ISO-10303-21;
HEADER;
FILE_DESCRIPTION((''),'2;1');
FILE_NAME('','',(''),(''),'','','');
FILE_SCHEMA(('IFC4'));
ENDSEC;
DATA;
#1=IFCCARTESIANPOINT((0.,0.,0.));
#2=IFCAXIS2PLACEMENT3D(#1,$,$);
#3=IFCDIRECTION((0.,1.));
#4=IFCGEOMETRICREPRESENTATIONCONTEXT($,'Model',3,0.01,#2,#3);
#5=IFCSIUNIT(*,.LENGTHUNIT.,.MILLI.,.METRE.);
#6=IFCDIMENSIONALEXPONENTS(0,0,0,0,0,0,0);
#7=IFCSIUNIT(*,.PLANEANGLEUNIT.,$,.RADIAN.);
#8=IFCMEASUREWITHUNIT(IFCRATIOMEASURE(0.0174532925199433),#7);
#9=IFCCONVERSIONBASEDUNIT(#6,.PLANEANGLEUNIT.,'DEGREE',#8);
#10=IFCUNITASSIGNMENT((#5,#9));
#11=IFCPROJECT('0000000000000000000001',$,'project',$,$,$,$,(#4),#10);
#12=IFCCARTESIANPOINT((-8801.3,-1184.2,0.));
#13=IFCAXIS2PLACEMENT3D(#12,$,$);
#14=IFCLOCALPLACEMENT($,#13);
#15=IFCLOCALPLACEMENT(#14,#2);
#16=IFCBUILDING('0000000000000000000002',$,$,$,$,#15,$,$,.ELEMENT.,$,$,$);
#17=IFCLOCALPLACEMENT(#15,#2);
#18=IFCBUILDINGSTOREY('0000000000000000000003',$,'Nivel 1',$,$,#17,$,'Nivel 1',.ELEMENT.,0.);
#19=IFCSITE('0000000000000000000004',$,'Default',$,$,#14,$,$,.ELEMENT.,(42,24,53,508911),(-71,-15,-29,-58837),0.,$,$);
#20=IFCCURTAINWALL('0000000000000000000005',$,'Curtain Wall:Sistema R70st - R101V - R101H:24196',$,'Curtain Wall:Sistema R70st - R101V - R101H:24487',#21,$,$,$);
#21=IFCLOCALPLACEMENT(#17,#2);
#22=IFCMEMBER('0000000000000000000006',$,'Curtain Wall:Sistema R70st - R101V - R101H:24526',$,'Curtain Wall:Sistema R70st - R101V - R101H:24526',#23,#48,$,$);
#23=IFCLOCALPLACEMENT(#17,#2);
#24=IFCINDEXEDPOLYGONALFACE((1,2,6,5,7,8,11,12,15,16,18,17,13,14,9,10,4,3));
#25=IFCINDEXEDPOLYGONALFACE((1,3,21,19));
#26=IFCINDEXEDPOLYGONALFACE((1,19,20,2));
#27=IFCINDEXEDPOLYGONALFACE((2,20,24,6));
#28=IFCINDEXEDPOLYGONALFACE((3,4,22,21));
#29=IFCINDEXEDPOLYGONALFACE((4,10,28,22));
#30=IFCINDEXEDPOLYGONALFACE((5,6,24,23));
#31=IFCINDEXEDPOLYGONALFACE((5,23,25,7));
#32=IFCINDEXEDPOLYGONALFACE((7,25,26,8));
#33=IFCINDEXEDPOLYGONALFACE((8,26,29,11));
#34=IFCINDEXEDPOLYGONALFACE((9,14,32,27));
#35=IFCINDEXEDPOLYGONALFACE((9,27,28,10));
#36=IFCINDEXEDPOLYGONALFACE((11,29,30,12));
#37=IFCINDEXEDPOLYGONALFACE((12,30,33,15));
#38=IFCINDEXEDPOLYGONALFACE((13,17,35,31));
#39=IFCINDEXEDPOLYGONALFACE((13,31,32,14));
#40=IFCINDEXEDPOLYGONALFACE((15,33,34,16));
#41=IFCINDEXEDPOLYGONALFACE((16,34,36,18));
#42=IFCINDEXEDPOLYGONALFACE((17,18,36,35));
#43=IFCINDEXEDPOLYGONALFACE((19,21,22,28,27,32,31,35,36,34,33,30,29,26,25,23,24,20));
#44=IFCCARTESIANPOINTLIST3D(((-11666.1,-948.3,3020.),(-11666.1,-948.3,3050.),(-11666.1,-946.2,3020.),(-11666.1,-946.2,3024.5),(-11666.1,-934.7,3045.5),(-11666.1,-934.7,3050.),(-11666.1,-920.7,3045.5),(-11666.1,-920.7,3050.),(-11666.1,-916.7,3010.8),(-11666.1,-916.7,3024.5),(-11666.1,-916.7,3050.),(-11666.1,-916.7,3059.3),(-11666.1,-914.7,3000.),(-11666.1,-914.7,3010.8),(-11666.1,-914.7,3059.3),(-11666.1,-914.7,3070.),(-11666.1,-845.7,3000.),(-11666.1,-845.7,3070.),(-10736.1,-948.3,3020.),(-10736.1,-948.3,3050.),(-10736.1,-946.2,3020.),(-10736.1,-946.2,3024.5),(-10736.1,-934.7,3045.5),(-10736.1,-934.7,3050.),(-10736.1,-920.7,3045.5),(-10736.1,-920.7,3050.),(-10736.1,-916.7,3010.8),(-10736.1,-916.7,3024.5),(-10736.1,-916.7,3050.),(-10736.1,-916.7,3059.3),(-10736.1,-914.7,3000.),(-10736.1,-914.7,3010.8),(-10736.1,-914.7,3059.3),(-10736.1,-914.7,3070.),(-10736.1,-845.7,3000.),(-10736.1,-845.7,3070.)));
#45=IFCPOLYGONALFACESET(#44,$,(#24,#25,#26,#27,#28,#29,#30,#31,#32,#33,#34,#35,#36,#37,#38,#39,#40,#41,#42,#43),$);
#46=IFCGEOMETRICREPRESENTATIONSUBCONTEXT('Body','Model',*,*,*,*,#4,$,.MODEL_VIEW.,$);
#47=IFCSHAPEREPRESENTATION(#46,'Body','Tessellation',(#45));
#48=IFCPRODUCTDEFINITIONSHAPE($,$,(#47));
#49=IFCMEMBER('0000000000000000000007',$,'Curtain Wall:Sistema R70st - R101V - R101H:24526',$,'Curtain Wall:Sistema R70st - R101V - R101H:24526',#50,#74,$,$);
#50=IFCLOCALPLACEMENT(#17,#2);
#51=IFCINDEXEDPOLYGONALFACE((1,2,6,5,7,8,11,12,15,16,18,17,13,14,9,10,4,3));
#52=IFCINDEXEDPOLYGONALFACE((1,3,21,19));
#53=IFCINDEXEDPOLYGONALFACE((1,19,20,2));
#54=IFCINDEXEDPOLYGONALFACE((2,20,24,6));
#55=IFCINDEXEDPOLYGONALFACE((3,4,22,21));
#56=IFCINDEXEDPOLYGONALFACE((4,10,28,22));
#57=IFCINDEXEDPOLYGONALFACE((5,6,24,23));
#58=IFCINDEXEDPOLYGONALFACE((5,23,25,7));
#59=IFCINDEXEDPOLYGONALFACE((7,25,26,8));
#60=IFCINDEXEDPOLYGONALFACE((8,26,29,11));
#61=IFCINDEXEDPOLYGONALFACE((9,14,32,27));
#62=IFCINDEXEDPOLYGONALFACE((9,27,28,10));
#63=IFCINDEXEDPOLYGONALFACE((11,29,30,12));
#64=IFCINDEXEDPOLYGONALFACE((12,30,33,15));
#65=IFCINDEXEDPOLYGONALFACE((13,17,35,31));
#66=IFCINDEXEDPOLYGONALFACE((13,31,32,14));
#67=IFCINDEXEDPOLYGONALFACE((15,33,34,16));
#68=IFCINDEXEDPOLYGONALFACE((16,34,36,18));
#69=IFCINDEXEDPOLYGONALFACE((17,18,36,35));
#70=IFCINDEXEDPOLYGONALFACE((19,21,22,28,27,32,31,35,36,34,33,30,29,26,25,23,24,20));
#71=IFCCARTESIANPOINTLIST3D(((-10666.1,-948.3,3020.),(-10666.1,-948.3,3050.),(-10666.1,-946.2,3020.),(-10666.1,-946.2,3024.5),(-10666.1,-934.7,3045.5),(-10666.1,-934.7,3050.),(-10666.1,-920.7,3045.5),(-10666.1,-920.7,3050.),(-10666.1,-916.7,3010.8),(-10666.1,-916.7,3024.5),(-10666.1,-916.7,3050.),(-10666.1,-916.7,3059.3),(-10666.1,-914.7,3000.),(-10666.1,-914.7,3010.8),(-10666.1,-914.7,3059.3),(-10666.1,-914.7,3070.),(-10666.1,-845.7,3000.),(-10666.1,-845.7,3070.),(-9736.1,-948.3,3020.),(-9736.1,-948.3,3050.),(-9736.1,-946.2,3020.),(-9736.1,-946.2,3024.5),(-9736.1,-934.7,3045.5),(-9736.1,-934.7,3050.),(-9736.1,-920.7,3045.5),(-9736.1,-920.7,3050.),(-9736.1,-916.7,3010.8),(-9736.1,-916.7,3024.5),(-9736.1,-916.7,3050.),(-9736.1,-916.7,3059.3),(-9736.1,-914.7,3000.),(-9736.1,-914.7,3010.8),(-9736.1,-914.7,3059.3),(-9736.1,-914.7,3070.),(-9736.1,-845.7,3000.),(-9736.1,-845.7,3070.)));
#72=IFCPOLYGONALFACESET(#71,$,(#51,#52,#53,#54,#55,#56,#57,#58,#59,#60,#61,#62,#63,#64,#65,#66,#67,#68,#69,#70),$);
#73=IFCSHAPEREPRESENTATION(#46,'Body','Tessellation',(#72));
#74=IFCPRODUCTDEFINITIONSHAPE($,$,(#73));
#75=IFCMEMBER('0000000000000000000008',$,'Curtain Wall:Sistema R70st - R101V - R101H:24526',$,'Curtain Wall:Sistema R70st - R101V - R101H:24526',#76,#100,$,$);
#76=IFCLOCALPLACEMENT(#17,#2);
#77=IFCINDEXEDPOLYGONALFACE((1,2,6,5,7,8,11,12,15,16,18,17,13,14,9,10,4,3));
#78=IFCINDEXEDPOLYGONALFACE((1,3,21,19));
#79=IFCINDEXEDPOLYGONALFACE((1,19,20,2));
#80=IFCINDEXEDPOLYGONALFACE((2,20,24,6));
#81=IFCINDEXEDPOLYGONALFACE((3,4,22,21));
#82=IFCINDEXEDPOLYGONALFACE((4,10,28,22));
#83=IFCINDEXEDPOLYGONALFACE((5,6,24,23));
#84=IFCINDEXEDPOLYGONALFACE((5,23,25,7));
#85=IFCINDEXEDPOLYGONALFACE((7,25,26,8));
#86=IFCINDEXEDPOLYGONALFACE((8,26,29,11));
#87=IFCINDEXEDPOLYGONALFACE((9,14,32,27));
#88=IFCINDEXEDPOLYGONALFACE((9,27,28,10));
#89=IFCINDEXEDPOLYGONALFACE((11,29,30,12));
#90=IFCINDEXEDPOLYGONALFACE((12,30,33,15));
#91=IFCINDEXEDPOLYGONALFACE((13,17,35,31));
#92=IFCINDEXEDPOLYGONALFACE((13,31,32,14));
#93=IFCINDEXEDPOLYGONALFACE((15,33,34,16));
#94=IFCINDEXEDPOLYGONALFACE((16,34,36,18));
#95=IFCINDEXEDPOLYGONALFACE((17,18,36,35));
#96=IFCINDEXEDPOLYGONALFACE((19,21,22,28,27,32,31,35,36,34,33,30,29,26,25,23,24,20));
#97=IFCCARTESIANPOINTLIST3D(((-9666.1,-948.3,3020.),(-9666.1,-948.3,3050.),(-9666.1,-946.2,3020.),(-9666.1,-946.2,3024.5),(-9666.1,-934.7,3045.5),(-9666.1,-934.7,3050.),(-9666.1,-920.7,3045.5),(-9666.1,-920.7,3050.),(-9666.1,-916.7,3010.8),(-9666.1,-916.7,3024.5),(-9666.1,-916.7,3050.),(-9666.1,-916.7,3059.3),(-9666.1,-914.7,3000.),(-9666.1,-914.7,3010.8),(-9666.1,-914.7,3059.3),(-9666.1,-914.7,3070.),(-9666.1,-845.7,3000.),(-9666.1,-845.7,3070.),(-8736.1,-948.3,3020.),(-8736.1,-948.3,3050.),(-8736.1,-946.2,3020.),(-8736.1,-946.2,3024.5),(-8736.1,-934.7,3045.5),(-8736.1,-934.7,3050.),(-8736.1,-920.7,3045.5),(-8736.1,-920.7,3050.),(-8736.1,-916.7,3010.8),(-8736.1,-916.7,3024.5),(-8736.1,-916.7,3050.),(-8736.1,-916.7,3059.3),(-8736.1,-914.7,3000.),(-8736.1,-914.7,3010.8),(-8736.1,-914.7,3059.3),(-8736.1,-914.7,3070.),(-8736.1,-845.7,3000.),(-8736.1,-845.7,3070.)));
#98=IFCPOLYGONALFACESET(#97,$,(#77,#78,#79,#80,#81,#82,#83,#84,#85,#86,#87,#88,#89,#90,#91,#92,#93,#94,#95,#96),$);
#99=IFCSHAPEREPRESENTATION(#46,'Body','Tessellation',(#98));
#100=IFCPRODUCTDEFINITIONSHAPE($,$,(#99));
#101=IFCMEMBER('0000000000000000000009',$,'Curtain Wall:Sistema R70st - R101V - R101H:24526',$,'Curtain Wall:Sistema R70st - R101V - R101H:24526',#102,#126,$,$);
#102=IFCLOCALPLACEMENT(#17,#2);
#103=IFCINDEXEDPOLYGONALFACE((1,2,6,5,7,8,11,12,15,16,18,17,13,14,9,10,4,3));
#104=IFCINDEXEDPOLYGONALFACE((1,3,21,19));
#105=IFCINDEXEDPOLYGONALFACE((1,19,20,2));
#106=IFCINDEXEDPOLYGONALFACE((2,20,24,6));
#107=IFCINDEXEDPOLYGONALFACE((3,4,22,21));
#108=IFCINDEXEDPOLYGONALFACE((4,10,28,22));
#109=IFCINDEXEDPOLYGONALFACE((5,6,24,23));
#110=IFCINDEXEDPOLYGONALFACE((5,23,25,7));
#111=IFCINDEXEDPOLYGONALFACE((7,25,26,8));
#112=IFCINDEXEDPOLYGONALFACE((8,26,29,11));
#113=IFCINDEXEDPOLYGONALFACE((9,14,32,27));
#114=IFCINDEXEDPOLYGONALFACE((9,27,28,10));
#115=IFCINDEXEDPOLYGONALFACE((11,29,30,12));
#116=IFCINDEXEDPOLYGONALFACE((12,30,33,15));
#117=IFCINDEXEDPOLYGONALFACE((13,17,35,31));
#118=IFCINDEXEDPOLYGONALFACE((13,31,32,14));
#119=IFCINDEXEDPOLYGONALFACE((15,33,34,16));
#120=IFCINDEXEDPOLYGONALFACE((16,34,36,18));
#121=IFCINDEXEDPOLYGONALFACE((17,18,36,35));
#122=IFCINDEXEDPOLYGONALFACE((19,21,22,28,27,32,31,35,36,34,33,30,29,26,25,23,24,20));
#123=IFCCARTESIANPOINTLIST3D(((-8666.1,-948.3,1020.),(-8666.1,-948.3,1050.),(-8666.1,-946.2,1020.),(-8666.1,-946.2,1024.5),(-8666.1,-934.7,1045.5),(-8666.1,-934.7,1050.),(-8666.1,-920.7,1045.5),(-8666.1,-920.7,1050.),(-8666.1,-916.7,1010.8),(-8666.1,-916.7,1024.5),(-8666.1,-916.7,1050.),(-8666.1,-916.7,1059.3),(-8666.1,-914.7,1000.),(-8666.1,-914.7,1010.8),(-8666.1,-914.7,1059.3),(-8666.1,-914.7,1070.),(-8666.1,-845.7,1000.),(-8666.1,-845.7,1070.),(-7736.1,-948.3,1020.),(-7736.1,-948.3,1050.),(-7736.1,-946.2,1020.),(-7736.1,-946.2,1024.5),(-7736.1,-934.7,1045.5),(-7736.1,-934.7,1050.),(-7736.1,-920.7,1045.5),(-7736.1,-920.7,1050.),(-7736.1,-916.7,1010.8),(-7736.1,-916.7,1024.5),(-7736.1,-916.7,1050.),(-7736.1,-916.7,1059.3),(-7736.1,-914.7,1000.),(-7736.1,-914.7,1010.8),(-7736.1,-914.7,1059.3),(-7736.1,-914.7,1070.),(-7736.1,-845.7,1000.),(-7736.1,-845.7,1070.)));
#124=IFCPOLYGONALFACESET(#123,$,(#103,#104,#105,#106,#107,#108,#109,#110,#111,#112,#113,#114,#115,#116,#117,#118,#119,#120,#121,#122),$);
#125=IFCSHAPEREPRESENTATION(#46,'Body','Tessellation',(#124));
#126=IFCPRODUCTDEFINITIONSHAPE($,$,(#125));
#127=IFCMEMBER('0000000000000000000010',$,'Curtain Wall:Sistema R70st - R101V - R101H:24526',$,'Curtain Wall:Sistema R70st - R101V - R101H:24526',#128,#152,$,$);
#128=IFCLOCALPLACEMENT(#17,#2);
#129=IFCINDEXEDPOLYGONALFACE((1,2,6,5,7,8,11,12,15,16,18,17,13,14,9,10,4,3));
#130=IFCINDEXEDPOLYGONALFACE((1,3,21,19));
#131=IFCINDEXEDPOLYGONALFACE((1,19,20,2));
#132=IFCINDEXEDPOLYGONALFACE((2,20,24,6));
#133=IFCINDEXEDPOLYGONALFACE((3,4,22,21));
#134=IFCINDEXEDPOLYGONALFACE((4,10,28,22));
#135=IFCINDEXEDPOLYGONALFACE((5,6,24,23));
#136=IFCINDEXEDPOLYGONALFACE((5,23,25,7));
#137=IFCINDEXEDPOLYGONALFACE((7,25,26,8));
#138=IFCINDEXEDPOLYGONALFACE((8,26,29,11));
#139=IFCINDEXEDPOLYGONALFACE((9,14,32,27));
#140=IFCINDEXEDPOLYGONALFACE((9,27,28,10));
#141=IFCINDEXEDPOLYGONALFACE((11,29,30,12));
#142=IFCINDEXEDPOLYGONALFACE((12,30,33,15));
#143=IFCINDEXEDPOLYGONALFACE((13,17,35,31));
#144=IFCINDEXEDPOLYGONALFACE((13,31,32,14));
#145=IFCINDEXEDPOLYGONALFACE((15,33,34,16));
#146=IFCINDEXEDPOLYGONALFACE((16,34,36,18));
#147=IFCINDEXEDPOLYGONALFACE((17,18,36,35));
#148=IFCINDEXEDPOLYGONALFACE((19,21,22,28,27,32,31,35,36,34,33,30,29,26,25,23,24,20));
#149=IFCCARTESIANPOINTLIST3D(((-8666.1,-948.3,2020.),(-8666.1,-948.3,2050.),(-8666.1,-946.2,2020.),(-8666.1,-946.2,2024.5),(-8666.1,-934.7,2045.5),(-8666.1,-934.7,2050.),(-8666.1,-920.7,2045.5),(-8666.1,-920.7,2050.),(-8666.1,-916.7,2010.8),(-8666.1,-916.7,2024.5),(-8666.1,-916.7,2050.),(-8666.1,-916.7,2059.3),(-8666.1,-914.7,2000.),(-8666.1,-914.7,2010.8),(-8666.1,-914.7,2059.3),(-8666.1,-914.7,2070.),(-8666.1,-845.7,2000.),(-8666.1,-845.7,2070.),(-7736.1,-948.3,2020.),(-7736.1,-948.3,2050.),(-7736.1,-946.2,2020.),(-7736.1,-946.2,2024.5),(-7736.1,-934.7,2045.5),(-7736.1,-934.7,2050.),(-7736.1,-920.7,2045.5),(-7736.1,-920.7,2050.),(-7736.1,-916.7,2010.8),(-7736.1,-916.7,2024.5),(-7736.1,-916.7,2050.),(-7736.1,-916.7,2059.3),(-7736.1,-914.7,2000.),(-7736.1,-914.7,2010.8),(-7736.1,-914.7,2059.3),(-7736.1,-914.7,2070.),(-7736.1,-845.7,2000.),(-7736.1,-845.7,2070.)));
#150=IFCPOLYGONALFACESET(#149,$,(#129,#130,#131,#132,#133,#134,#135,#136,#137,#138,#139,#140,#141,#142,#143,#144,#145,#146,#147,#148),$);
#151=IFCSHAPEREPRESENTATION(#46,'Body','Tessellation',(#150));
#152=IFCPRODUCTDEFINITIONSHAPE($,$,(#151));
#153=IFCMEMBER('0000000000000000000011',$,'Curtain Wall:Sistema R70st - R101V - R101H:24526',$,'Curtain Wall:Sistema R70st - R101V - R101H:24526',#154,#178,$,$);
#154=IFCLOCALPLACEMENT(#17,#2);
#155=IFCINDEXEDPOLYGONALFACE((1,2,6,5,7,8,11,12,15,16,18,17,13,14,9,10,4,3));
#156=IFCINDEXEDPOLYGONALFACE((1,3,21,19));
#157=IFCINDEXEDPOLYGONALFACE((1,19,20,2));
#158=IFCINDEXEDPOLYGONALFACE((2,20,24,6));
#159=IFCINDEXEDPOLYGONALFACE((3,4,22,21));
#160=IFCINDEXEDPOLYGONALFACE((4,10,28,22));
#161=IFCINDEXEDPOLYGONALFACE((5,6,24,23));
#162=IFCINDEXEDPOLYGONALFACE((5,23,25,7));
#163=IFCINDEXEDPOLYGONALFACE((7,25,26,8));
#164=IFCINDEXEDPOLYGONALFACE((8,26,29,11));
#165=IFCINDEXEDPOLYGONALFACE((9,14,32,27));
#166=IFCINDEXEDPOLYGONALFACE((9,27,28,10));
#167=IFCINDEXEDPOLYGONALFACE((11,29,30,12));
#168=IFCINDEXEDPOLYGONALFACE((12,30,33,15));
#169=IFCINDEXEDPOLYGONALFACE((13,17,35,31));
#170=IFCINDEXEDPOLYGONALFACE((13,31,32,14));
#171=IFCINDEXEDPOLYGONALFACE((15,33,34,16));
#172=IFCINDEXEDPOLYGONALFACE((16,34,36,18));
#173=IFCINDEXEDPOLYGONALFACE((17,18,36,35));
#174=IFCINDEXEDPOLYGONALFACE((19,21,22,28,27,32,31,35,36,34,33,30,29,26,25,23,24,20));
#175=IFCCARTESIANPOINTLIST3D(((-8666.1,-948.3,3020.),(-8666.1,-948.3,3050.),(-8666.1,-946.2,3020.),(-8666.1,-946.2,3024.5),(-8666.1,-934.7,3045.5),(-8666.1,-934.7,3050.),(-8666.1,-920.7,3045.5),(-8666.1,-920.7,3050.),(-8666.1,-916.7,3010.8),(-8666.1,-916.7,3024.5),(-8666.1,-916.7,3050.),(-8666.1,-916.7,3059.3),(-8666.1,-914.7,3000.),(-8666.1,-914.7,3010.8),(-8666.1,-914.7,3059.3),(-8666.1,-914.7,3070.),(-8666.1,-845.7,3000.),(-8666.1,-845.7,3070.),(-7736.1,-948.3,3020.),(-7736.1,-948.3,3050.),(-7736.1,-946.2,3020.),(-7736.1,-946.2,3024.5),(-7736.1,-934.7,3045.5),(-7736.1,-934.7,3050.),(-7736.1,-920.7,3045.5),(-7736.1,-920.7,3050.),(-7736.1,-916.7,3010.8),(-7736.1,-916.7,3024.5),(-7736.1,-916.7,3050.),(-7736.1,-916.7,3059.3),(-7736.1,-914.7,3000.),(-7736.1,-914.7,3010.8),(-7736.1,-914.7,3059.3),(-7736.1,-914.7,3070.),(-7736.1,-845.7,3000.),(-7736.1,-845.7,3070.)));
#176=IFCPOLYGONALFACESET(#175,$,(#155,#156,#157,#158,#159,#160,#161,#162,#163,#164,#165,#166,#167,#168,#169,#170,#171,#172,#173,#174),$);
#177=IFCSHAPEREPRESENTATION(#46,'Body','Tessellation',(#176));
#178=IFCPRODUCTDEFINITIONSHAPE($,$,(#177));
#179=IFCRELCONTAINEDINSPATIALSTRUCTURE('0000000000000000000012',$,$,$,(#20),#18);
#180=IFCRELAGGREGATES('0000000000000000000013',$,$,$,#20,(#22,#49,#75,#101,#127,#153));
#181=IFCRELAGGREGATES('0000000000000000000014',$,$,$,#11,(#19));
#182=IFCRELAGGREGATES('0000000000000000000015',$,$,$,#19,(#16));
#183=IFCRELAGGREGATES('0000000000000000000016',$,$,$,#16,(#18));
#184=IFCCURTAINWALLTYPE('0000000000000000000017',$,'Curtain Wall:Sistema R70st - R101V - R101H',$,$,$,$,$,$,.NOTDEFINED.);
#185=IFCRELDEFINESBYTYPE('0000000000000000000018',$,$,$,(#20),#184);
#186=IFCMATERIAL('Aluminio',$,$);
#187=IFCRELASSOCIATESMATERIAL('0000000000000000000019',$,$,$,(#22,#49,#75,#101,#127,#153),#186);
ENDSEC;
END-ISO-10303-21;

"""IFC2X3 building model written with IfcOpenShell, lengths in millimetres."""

from ifc_helpers import new_model, entity, si_unit, converted_unit, direction, frame, origin, place, context, subcontext, project, spatial, polyline, outline, extrude, material, type_object, element, aggregate, save


model = new_model("IFC2X3")

# Units and contexts
model_context = context("Model", 3, precision=0.01, world=origin(), true_north=direction((0.0, 1.0)))
body_context = subcontext(model_context, "Body", "Model", "MODEL_VIEW")
ifc_project = project(units=[si_unit("LENGTHUNIT", "METRE", prefix="MILLI"), converted_unit("PLANEANGLEUNIT", "DEGREE", entity("IfcRatioMeasure", 0.0174532925199433), si_unit("PLANEANGLEUNIT", "RADIAN"), dimensions=[0, 0, 0, 0, 0, 0, 0])], contexts=[model_context])

# Site, building, storey
site_placement = place(None, frame((-8801.3, -1184.2, 0.0)))
site = spatial("IfcSite", under=ifc_project, at=site_placement, Name="Default", CompositionType="ELEMENT", RefLatitude=(42, 24, 53, 508911), RefLongitude=(-71, -15, -29, -58837), RefElevation=0.0)
building_placement = place(site_placement, origin())
building = spatial("IfcBuilding", under=site, at=building_placement, CompositionType="ELEMENT")
storey_placement = place(building_placement, origin())
storey = spatial("IfcBuildingStorey", under=building, at=storey_placement, Name="Nivel 1", LongName="Nivel 1", CompositionType="ELEMENT", Elevation=0.0)

# Curtain wall, members
curtain_wall_type = type_object("IfcCurtainWallType", Name="Curtain Wall:Sistema R70st - R101V - R101H", PredefinedType="NOTDEFINED")
curtain_wall_placement = place(storey_placement, origin())
curtain_wall = element("IfcCurtainWall", 1, at=curtain_wall_placement, inside=storey, type_object=curtain_wall_type, Name="Curtain Wall:Sistema R70st - R101V - R101H:24196", ObjectType="Curtain Wall:Sistema R70st - R101V - R101H:24487")
ifc_material = material(Name="Aluminio")
member_1_placement = place(curtain_wall_placement, origin())
member_1 = element("IfcMember", 2, at=member_1_placement, material=ifc_material, Name="Curtain Wall:Sistema R70st - R101V - R101H:24526", ObjectType="Curtain Wall:Sistema R70st - R101V - R101H:24526", context=body_context, shape_type="SweptSolid", body=[
    extrude(outline(polyline([(-33.3, -71.9), (36.7, -71.9), (36.7, -2.9), (25.9, -2.9), (25.9, -0.9), (12.2, -0.9), (12.2, 28.6), (16.7, 28.6), (16.7, 30.7), (-13.3, 30.7), (-13.3, 17.1), (-8.8, 17.1), (-8.8, 3.1), (-13.3, 3.1), (-13.3, -0.9), (-22.6, -0.9), (-22.6, -2.9), (-33.3, -2.9), (-33.3, -71.9)])), frame((-10736.1, -917.6, 3036.7), z_axis=(-1.0, 0.0, 0.0), x_axis=(0.0, 0.0, -1.0)), (0.0, 0.0, 1.0), 930.0),
])
member_2_placement = place(curtain_wall_placement, origin())
member_2 = element("IfcMember", 3, at=member_2_placement, material=ifc_material, Name="Curtain Wall:Sistema R70st - R101V - R101H:24526", ObjectType="Curtain Wall:Sistema R70st - R101V - R101H:24526", context=body_context, shape_type="SweptSolid", body=[
    extrude(outline(polyline([(-33.3, -71.9), (36.7, -71.9), (36.7, -2.9), (25.9, -2.9), (25.9, -0.9), (12.2, -0.9), (12.2, 28.6), (16.7, 28.6), (16.7, 30.7), (-13.3, 30.7), (-13.3, 17.1), (-8.8, 17.1), (-8.8, 3.1), (-13.3, 3.1), (-13.3, -0.9), (-22.6, -0.9), (-22.6, -2.9), (-33.3, -2.9), (-33.3, -71.9)])), frame((-9736.1, -917.6, 3036.7), z_axis=(-1.0, 0.0, 0.0), x_axis=(0.0, 0.0, -1.0)), (0.0, 0.0, 1.0), 930.0),
])
member_3_placement = place(curtain_wall_placement, origin())
member_3 = element("IfcMember", 4, at=member_3_placement, material=ifc_material, Name="Curtain Wall:Sistema R70st - R101V - R101H:24526", ObjectType="Curtain Wall:Sistema R70st - R101V - R101H:24526", context=body_context, shape_type="SweptSolid", body=[
    extrude(outline(polyline([(-33.3, -71.9), (36.7, -71.9), (36.7, -2.9), (25.9, -2.9), (25.9, -0.9), (12.2, -0.9), (12.2, 28.6), (16.7, 28.6), (16.7, 30.7), (-13.3, 30.7), (-13.3, 17.1), (-8.8, 17.1), (-8.8, 3.1), (-13.3, 3.1), (-13.3, -0.9), (-22.6, -0.9), (-22.6, -2.9), (-33.3, -2.9), (-33.3, -71.9)])), frame((-8736.1, -917.6, 3036.7), z_axis=(-1.0, 0.0, 0.0), x_axis=(0.0, 0.0, -1.0)), (0.0, 0.0, 1.0), 930.0),
])
member_4_placement = place(curtain_wall_placement, origin())
member_4 = element("IfcMember", 5, at=member_4_placement, material=ifc_material, Name="Curtain Wall:Sistema R70st - R101V - R101H:24526", ObjectType="Curtain Wall:Sistema R70st - R101V - R101H:24526", context=body_context, shape_type="SweptSolid", body=[
    extrude(outline(polyline([(-33.3, -71.9), (36.7, -71.9), (36.7, -2.9), (25.9, -2.9), (25.9, -0.9), (12.2, -0.9), (12.2, 28.6), (16.7, 28.6), (16.7, 30.7), (-13.3, 30.7), (-13.3, 17.1), (-8.8, 17.1), (-8.8, 3.1), (-13.3, 3.1), (-13.3, -0.9), (-22.6, -0.9), (-22.6, -2.9), (-33.3, -2.9), (-33.3, -71.9)])), frame((-7736.1, -917.6, 1036.7), z_axis=(-1.0, 0.0, 0.0), x_axis=(0.0, 0.0, -1.0)), (0.0, 0.0, 1.0), 930.0),
])
member_5_placement = place(curtain_wall_placement, origin())
member_5 = element("IfcMember", 6, at=member_5_placement, material=ifc_material, Name="Curtain Wall:Sistema R70st - R101V - R101H:24526", ObjectType="Curtain Wall:Sistema R70st - R101V - R101H:24526", context=body_context, shape_type="SweptSolid", body=[
    extrude(outline(polyline([(-33.3, -71.9), (36.7, -71.9), (36.7, -2.9), (25.9, -2.9), (25.9, -0.9), (12.2, -0.9), (12.2, 28.6), (16.7, 28.6), (16.7, 30.7), (-13.3, 30.7), (-13.3, 17.1), (-8.8, 17.1), (-8.8, 3.1), (-13.3, 3.1), (-13.3, -0.9), (-22.6, -0.9), (-22.6, -2.9), (-33.3, -2.9), (-33.3, -71.9)])), frame((-7736.1, -917.6, 2036.7), z_axis=(-1.0, 0.0, 0.0), x_axis=(0.0, 0.0, -1.0)), (0.0, 0.0, 1.0), 930.0),
])
member_6_placement = place(curtain_wall_placement, origin())
member_6 = element("IfcMember", 7, at=member_6_placement, material=ifc_material, Name="Curtain Wall:Sistema R70st - R101V - R101H:24526", ObjectType="Curtain Wall:Sistema R70st - R101V - R101H:24526", context=body_context, shape_type="SweptSolid", body=[
    extrude(outline(polyline([(-33.3, -71.9), (36.7, -71.9), (36.7, -2.9), (25.9, -2.9), (25.9, -0.9), (12.2, -0.9), (12.2, 28.6), (16.7, 28.6), (16.7, 30.7), (-13.3, 30.7), (-13.3, 17.1), (-8.8, 17.1), (-8.8, 3.1), (-13.3, 3.1), (-13.3, -0.9), (-22.6, -0.9), (-22.6, -2.9), (-33.3, -2.9), (-33.3, -71.9)])), frame((-7736.1, -917.6, 3036.7), z_axis=(-1.0, 0.0, 0.0), x_axis=(0.0, 0.0, -1.0)), (0.0, 0.0, 1.0), 930.0),
])
aggregate(curtain_wall, [member_1, member_2, member_3, member_4, member_5, member_6])

save(model, "model.ifc")
